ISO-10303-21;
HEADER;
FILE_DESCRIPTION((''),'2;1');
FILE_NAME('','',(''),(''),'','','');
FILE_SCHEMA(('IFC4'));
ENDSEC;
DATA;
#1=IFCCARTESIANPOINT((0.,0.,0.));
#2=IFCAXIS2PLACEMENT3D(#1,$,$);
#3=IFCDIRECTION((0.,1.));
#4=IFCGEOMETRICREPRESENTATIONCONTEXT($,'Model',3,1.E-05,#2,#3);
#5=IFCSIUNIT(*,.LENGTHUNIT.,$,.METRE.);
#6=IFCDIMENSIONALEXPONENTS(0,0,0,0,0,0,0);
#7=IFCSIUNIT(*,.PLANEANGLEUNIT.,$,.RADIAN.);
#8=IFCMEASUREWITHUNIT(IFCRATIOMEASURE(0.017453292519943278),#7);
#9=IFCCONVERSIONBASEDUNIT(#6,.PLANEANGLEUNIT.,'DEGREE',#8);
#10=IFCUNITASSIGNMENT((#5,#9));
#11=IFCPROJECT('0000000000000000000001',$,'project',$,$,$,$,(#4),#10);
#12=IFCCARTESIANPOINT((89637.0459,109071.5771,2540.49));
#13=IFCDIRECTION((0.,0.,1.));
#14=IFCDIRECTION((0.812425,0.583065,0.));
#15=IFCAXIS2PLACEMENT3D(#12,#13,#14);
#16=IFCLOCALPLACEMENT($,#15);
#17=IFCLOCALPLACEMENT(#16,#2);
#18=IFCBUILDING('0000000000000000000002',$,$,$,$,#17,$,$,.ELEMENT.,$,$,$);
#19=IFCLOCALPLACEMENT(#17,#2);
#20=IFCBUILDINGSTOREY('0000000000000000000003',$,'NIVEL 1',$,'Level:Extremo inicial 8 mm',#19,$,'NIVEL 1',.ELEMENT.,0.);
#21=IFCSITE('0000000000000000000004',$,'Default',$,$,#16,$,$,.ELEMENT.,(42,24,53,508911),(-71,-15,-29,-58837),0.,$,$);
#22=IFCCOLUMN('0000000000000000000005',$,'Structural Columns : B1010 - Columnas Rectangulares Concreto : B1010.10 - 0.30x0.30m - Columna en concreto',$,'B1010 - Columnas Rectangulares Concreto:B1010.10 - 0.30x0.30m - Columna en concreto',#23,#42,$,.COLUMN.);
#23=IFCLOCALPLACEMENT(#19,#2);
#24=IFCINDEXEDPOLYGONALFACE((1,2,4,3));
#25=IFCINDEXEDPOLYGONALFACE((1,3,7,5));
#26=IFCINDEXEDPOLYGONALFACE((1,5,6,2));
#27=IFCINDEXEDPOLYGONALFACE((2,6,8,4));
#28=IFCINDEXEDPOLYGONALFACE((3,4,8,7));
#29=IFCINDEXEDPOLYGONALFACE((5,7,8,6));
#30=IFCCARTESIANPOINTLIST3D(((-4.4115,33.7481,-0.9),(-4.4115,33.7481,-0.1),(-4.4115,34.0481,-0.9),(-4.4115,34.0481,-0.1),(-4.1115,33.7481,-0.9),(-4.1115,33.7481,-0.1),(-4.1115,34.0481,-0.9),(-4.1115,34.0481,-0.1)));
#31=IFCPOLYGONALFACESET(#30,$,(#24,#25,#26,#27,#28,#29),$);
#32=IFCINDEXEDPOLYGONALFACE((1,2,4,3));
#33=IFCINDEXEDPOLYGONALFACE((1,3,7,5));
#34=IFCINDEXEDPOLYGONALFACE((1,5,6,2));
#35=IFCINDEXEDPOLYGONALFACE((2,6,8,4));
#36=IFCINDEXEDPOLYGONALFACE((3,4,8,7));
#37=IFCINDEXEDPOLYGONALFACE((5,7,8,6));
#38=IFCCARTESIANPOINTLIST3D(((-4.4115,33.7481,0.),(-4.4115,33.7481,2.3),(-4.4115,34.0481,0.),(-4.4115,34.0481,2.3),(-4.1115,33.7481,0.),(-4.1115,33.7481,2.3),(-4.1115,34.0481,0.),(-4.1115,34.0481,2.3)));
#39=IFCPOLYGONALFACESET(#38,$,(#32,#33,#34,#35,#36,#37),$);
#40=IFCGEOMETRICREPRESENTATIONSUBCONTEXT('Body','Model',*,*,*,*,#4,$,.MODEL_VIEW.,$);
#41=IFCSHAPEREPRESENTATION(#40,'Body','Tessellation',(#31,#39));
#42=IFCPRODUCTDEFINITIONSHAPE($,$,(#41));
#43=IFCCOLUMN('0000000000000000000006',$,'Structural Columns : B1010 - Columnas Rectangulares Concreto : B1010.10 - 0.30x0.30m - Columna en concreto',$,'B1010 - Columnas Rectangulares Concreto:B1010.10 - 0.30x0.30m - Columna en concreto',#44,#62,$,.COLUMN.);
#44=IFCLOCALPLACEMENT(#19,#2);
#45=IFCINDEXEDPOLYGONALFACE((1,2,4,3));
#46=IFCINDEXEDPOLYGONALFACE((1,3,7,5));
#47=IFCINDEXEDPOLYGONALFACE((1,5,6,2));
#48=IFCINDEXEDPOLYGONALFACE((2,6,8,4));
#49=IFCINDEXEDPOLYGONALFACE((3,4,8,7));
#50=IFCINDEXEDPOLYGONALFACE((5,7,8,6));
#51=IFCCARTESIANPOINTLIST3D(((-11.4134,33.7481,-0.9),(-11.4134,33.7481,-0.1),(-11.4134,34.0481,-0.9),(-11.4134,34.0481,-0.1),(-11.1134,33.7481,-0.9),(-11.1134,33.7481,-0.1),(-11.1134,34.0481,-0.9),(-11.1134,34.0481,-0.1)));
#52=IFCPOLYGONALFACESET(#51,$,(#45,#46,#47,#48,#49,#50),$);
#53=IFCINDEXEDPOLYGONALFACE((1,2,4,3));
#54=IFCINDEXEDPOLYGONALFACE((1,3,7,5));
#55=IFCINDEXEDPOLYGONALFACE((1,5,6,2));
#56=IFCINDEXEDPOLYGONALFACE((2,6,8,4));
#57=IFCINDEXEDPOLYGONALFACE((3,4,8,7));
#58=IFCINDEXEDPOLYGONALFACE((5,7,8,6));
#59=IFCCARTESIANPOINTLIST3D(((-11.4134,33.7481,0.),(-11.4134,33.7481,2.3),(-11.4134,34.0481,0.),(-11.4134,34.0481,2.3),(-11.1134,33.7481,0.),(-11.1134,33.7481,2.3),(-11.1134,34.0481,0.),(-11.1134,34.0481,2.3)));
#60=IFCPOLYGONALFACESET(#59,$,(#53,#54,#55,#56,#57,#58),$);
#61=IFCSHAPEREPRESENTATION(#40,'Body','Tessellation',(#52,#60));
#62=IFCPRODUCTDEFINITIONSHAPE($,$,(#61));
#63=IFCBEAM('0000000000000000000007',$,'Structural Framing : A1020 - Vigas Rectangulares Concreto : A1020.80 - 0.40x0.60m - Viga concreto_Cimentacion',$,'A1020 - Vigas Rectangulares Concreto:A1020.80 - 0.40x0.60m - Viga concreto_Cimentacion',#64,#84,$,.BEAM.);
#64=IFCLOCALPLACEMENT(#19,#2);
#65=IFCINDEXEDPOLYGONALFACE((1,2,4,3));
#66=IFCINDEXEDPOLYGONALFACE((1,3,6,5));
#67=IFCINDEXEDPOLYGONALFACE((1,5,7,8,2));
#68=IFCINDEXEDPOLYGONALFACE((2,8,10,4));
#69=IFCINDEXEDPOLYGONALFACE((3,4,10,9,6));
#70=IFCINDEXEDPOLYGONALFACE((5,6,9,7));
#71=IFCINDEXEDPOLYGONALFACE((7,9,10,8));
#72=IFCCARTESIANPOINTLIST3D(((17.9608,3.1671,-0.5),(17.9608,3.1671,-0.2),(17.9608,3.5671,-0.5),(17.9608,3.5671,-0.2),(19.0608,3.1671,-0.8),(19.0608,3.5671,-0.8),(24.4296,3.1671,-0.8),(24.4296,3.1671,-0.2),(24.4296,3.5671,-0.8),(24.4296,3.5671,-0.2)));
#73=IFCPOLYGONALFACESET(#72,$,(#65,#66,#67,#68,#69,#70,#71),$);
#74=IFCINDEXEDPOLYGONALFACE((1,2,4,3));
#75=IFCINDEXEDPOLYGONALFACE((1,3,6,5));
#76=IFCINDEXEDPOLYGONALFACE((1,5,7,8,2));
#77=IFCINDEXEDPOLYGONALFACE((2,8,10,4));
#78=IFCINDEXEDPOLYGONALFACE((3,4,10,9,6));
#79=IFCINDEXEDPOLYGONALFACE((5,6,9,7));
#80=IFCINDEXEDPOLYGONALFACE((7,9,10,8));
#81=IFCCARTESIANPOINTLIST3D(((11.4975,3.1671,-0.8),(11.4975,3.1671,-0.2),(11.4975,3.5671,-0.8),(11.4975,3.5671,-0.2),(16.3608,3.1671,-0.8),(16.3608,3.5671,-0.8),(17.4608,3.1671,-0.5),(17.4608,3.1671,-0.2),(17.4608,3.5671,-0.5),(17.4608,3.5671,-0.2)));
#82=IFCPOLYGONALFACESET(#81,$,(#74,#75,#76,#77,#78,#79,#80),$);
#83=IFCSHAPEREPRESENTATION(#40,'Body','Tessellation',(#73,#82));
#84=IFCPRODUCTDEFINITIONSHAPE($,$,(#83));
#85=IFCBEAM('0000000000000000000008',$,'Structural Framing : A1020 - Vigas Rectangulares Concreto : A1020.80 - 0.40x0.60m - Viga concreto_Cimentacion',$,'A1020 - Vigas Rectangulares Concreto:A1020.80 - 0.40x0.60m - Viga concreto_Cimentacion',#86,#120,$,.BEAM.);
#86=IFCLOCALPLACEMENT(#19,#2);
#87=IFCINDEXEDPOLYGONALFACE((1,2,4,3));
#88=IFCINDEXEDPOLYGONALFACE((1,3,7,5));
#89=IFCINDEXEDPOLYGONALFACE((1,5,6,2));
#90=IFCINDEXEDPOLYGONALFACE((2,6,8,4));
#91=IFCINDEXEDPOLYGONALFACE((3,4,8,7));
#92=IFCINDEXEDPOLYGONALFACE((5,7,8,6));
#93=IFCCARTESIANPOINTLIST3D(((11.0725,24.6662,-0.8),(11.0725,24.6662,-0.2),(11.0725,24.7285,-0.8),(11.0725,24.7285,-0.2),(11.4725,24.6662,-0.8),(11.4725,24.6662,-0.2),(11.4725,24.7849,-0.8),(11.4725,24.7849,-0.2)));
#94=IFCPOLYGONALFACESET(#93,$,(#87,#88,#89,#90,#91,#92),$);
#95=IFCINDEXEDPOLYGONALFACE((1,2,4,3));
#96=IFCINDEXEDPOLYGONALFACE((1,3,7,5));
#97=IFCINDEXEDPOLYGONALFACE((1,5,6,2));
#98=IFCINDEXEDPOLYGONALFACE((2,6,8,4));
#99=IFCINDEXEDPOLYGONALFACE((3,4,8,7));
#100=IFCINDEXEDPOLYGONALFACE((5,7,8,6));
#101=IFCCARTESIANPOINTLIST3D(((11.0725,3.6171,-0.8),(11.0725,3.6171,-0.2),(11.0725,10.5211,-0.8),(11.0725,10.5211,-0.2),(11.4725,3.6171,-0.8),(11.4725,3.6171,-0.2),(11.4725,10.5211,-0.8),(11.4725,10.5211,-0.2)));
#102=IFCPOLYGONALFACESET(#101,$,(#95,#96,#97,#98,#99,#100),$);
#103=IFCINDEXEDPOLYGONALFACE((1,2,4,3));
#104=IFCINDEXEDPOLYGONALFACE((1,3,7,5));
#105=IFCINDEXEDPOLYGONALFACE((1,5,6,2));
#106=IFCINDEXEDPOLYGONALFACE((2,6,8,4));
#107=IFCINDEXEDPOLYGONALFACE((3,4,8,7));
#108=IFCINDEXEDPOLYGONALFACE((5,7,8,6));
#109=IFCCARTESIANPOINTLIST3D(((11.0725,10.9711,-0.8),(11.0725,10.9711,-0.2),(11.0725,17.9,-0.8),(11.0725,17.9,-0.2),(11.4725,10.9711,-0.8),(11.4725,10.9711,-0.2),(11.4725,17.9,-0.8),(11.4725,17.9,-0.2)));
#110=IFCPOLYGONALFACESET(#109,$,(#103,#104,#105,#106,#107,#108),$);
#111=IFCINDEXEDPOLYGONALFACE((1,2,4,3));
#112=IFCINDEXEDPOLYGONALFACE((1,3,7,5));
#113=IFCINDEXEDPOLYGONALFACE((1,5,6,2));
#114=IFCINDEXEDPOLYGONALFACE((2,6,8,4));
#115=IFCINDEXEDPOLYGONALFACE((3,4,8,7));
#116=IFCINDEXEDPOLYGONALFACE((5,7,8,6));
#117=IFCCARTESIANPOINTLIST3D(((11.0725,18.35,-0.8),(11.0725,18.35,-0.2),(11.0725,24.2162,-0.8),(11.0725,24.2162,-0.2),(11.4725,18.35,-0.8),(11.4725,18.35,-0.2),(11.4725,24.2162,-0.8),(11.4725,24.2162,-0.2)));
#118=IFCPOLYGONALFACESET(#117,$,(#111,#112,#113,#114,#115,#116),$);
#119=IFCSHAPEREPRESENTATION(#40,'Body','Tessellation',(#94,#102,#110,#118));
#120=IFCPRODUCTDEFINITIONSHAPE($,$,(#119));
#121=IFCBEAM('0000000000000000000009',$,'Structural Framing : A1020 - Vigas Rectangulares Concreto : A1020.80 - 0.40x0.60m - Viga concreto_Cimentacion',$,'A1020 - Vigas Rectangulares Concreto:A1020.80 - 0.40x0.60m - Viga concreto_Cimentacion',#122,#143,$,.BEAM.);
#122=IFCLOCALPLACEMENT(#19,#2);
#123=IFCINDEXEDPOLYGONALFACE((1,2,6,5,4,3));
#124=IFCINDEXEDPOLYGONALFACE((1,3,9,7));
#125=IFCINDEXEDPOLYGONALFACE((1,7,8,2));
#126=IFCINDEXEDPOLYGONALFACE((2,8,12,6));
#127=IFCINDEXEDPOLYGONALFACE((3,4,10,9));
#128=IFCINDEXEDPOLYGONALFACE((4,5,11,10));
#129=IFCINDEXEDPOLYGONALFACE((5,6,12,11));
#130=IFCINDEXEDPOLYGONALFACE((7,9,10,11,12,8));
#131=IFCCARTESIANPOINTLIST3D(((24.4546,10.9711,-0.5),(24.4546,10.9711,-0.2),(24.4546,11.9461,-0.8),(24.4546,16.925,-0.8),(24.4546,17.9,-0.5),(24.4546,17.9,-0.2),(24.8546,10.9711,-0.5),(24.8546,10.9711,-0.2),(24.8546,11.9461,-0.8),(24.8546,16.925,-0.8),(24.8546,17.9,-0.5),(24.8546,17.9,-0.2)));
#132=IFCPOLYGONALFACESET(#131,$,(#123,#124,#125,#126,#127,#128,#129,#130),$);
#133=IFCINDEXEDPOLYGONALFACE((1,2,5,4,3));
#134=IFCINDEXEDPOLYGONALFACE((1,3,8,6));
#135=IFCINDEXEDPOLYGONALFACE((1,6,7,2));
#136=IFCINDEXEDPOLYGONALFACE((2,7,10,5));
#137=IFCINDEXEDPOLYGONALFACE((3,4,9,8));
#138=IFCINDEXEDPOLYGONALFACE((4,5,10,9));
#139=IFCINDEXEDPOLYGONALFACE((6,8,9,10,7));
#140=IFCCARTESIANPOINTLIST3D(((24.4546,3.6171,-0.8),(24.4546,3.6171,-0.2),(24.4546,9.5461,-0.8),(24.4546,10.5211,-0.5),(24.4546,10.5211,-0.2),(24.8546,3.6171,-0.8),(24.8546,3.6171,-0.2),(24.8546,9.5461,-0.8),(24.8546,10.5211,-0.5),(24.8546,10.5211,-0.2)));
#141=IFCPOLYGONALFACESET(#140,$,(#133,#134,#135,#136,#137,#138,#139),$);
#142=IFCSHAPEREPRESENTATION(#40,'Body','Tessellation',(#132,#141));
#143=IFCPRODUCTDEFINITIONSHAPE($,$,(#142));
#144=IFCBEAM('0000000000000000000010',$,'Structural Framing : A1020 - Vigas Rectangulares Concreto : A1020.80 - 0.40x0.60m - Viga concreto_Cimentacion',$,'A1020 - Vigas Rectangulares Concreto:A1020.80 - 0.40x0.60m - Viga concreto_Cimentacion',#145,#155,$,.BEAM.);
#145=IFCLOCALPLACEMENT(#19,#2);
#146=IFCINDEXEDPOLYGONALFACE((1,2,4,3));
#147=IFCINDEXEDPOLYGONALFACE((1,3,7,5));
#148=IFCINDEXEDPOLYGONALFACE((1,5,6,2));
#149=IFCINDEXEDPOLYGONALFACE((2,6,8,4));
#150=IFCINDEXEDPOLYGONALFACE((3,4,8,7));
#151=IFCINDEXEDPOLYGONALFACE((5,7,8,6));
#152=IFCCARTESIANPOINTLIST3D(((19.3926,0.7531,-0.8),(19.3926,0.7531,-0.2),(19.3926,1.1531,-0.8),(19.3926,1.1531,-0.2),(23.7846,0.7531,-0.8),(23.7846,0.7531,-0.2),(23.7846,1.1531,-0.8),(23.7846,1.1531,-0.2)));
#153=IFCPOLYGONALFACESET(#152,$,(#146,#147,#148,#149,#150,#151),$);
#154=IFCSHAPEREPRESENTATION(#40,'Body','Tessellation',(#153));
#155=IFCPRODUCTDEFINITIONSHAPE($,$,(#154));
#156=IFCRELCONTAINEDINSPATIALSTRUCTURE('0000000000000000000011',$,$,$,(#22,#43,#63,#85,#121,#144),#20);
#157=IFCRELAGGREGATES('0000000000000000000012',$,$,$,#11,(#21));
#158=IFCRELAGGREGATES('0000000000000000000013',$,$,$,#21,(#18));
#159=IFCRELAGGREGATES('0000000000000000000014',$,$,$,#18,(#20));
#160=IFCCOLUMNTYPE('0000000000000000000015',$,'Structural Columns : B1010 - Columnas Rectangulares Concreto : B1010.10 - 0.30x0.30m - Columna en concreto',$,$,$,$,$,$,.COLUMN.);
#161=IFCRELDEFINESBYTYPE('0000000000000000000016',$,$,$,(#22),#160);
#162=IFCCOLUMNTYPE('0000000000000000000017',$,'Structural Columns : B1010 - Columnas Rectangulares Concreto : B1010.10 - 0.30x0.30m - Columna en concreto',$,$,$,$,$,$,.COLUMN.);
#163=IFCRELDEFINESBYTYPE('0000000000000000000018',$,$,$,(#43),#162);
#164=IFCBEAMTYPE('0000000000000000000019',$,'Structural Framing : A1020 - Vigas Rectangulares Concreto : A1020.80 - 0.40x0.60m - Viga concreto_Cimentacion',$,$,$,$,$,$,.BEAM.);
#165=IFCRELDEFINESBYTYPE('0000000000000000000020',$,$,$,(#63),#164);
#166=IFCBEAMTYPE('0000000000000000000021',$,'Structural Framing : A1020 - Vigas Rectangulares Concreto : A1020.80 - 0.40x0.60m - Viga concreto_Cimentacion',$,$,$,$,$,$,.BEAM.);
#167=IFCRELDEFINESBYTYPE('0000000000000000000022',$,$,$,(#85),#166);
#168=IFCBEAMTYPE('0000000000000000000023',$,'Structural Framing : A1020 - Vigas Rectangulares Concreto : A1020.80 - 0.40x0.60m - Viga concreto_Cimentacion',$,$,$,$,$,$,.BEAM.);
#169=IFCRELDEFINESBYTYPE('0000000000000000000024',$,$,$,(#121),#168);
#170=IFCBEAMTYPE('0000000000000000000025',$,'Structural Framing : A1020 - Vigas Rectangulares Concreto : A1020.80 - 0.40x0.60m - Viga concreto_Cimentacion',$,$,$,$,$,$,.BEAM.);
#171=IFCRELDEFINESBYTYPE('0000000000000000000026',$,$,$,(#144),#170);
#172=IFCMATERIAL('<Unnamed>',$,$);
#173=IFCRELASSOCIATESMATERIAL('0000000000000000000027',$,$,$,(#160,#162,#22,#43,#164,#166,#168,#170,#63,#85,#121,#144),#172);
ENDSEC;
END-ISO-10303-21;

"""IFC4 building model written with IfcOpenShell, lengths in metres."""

from ifc_helpers import new_model, entity, si_unit, converted_unit, direction, frame, frame_2d, origin, origin_2d_with_axis, place, context, subcontext, project, spatial, polyline, segment, composite_curve, rectangle, outline, extrude, clip, halfspace, source, transform, mapped, material, material_profile, profile_set, profile_usage, type_object, type_shapes, element, save


model = new_model("IFC4")

# Units and contexts
model_context = context("Model", 3, precision=1e-05, world=origin(), true_north=direction((0.0, 1.0)))
body_context = subcontext(model_context, "Body", "Model", "MODEL_VIEW")
ifc_project = project(units=[si_unit("LENGTHUNIT", "METRE"), converted_unit("PLANEANGLEUNIT", "DEGREE", entity("IfcRatioMeasure", 0.017453292519943278), si_unit("PLANEANGLEUNIT", "RADIAN"), dimensions=[0, 0, 0, 0, 0, 0, 0])], contexts=[model_context])

# Site, building, storey
site_placement = place(None, frame((89637.0459, 109071.5771, 2540.49), z_axis=(0.0, 0.0, 1.0), x_axis=(0.812425, 0.583065, 0.0)))
site = spatial("IfcSite", under=ifc_project, at=site_placement, Name="Default", CompositionType="ELEMENT", RefLatitude=(42, 24, 53, 508911), RefLongitude=(-71, -15, -29, -58837), RefElevation=0.0)
building_placement = place(site_placement, origin())
building = spatial("IfcBuilding", under=site, at=building_placement, CompositionType="ELEMENT")
storey_placement = place(building_placement, origin())
storey = spatial("IfcBuildingStorey", under=building, at=storey_placement, Name="NIVEL 1", ObjectType="Level:Extremo inicial 8 mm", LongName="NIVEL 1", CompositionType="ELEMENT", Elevation=0.0)

# Columns
ifc_material_1 = material(Name="<Unnamed>")
ifc_material_profile_1 = material_profile(ifc_material_1, outline(composite_curve([segment(polyline([(0.15, 0.15, 0.0), (0.15, -0.15, 0.0)]), True, "CONTINUOUS"), segment(polyline([(0.15, -0.15, 0.0), (-0.15, -0.15, 0.0)]), True, "CONTINUOUS"), segment(polyline([(-0.15, -0.15, 0.0), (-0.15, 0.15, 0.0)]), True, "CONTINUOUS"), segment(polyline([(-0.15, 0.15, 0.0), (0.15, 0.15, 0.0)]), True, "CONTINUOUS")], self_intersect=False), kind="CURVE"), Name="B1010.10 - 0.30x0.30m - Columna en concreto")
ifc_material_profile_2 = material_profile(ifc_material_1, outline(composite_curve([segment(polyline([(0.15, 0.15, 2.3), (-0.15, 0.15, 2.3)]), True, "CONTINUOUS"), segment(polyline([(-0.15, 0.15, 2.3), (-0.15, -0.15, 2.3)]), True, "CONTINUOUS"), segment(polyline([(-0.15, -0.15, 2.3), (0.15, -0.15, 2.3)]), True, "CONTINUOUS"), segment(polyline([(0.15, -0.15, 2.3), (0.15, 0.15, 2.3)]), True, "CONTINUOUS")], self_intersect=False), kind="CURVE"), Name="B1010.10 - 0.30x0.30m - Columna en concreto")
ifc_profile_set_1 = profile_set([ifc_material_profile_1, ifc_material_profile_2], Name="B1010.10 - 0.30x0.30m - Columna en concreto")
ifc_profile_usage_1 = profile_usage(ifc_profile_set_1)
column_type_1 = type_object("IfcColumnType", Name="Structural Columns : B1010 - Columnas Rectangulares Concreto : B1010.10 - 0.30x0.30m - Columna en concreto", PredefinedType="COLUMN", material=ifc_profile_set_1)
shared_shape_1 = source(origin(), body_context, "Body", "SweptSolid", [
    extrude(rectangle(XDim=0.3, YDim=0.3, at=origin_2d_with_axis()), frame((-4.2615, 33.8981, -0.9), z_axis=(0.0, 0.0, 1.0), x_axis=(0.0, -1.0, 0.0)), (0.0, 0.0, 1.0), 0.8),
    extrude(rectangle(XDim=0.3, YDim=0.3, at=origin_2d_with_axis()), frame((-4.2615, 33.8981, 0.0), z_axis=(0.0, 0.0, 1.0), x_axis=(0.0, -1.0, 0.0)), (0.0, 0.0, 1.0), 2.3),
])
type_shapes(column_type_1, [shared_shape_1])
column_1_placement = place(storey_placement, origin())
element("IfcColumn", 1, at=column_1_placement, inside=storey, type_object=column_type_1, material=ifc_profile_usage_1, Name="Structural Columns : B1010 - Columnas Rectangulares Concreto : B1010.10 - 0.30x0.30m - Columna en concreto", ObjectType="B1010 - Columnas Rectangulares Concreto:B1010.10 - 0.30x0.30m - Columna en concreto", PredefinedType="COLUMN", context=body_context, shape_type="MappedRepresentation", body=[
    mapped(shared_shape_1, transform((0.0, 0.0, 0.0), scale=1.0)),
])
ifc_profile_usage_2 = profile_usage(ifc_profile_set_1)
column_type_2 = type_object("IfcColumnType", Name="Structural Columns : B1010 - Columnas Rectangulares Concreto : B1010.10 - 0.30x0.30m - Columna en concreto", PredefinedType="COLUMN", material=ifc_profile_set_1)
shared_shape_2 = source(origin(), body_context, "Body", "SweptSolid", [
    extrude(rectangle(XDim=0.3, YDim=0.3, at=origin_2d_with_axis()), frame((-11.2634, 33.8981, -0.9), z_axis=(0.0, 0.0, 1.0), x_axis=(0.0, -1.0, 0.0)), (0.0, 0.0, 1.0), 0.8),
    extrude(rectangle(XDim=0.3, YDim=0.3, at=origin_2d_with_axis()), frame((-11.2634, 33.8981, 0.0), z_axis=(0.0, 0.0, 1.0), x_axis=(0.0, -1.0, 0.0)), (0.0, 0.0, 1.0), 2.3),
])
type_shapes(column_type_2, [shared_shape_2])
column_2_placement = place(storey_placement, origin())
element("IfcColumn", 2, at=column_2_placement, inside=storey, type_object=column_type_2, material=ifc_profile_usage_2, Name="Structural Columns : B1010 - Columnas Rectangulares Concreto : B1010.10 - 0.30x0.30m - Columna en concreto", ObjectType="B1010 - Columnas Rectangulares Concreto:B1010.10 - 0.30x0.30m - Columna en concreto", PredefinedType="COLUMN", context=body_context, shape_type="MappedRepresentation", body=[
    mapped(shared_shape_2, transform((0.0, 0.0, 0.0), scale=1.0)),
])

# Beams
ifc_material_profile_3 = material_profile(ifc_material_1, outline(composite_curve([segment(polyline([(-0.2, 0.3, 0.0), (0.2, 0.3, 0.0)]), True, "CONTINUOUS"), segment(polyline([(0.2, 0.3, 0.0), (0.2, -0.3, 0.0)]), True, "CONTINUOUS"), segment(polyline([(0.2, -0.3, 0.0), (-0.2, -0.3, 0.0)]), True, "CONTINUOUS"), segment(polyline([(-0.2, -0.3, 0.0), (-0.2, 0.3, 0.0)]), True, "CONTINUOUS")], self_intersect=False), kind="CURVE"), Name="A1020.80 - 0.40x0.60m - Viga concreto_Cimentacion")
ifc_material_profile_4 = material_profile(ifc_material_1, outline(composite_curve([segment(polyline([(6.4409, -0.2, 0.3), (6.4409, -0.2, -0.3)]), True, "CONTINUOUS"), segment(polyline([(6.4409, -0.2, -0.3), (6.4409, 0.2, -0.3)]), True, "CONTINUOUS"), segment(polyline([(6.4409, 0.2, -0.3), (6.4409, 0.2, 0.3)]), True, "CONTINUOUS"), segment(polyline([(6.4409, 0.2, 0.3), (6.4409, -0.2, 0.3)]), True, "CONTINUOUS")], self_intersect=False), kind="CURVE"), Name="A1020.80 - 0.40x0.60m - Viga concreto_Cimentacion")
ifc_profile_set_2 = profile_set([ifc_material_profile_3, ifc_material_profile_4], Name="A1020.80 - 0.40x0.60m - Viga concreto_Cimentacion")
ifc_profile_usage_3 = profile_usage(ifc_profile_set_2, cardinal=8)
beam_type_1 = type_object("IfcBeamType", Name="Structural Framing : A1020 - Vigas Rectangulares Concreto : A1020.80 - 0.40x0.60m - Viga concreto_Cimentacion", PredefinedType="BEAM", material=ifc_profile_set_2)
shared_shape_3 = source(origin(), body_context, "Body", "SweptSolid", [
    clip(extrude(rectangle(XDim=0.6, YDim=0.4, at=frame_2d((0.0, 0.0), x_axis=(0.0, 1.0))), frame((17.9608, 3.3671, -0.5), z_axis=(1.0, 0.0, 0.0), x_axis=(0.0, 1.0, 0.0)), (0.0, 0.0, 1.0), 6.4688), halfspace(frame((19.0608, 3.3671, -0.8), z_axis=(-0.263117, 0.0, -0.964764), x_axis=(0.0, 1.0, 0.0)), False)),
    clip(extrude(rectangle(XDim=0.6, YDim=0.4, at=frame_2d((0.0, 0.0), x_axis=(0.0, 1.0))), frame((11.4975, 3.3671, -0.5), z_axis=(1.0, 0.0, 0.0), x_axis=(0.0, 1.0, 0.0)), (0.0, 0.0, 1.0), 5.9633), halfspace(frame((16.3608, 3.3671, -0.8), z_axis=(0.263117, 0.0, -0.964764), x_axis=(0.0, -1.0, 0.0)), False)),
])
type_shapes(beam_type_1, [shared_shape_3])
beam_1_placement = place(storey_placement, origin())
element("IfcBeam", 3, at=beam_1_placement, inside=storey, type_object=beam_type_1, material=ifc_profile_usage_3, Name="Structural Framing : A1020 - Vigas Rectangulares Concreto : A1020.80 - 0.40x0.60m - Viga concreto_Cimentacion", ObjectType="A1020 - Vigas Rectangulares Concreto:A1020.80 - 0.40x0.60m - Viga concreto_Cimentacion", PredefinedType="BEAM", context=body_context, shape_type="MappedRepresentation", body=[
    mapped(shared_shape_3, transform((0.0, 0.0, 0.0), scale=1.0)),
])
ifc_profile_usage_4 = profile_usage(ifc_profile_set_2, cardinal=8)
beam_type_2 = type_object("IfcBeamType", Name="Structural Framing : A1020 - Vigas Rectangulares Concreto : A1020.80 - 0.40x0.60m - Viga concreto_Cimentacion", PredefinedType="BEAM", material=ifc_profile_set_2)
shared_shape_4 = source(origin(), body_context, "Body", "SweptSolid", [
    clip(extrude(rectangle(XDim=0.6, YDim=0.4, at=frame_2d((0.0, 0.0), x_axis=(0.0, 1.0))), frame((11.2725, 24.6662, -0.5), z_axis=(0.0, 1.0, 0.0), x_axis=(-1.0, 0.0, 0.0)), (0.0, 0.0, 1.0), 0.1187), halfspace(frame((10.9962, 24.7178, -0.2), z_axis=(-0.139655, 0.9902, 0.0), x_axis=(0.9902, 0.139655, 0.0)), False)),
    extrude(rectangle(XDim=0.6, YDim=0.4, at=frame_2d((0.0, 0.0), x_axis=(0.0, 1.0))), frame((11.2725, 3.6171, -0.5), z_axis=(0.0, 1.0, 0.0), x_axis=(-1.0, 0.0, 0.0)), (0.0, 0.0, 1.0), 6.904),
    extrude(rectangle(XDim=0.6, YDim=0.4, at=frame_2d((0.0, 0.0), x_axis=(0.0, 1.0))), frame((11.2725, 10.9711, -0.5), z_axis=(0.0, 1.0, 0.0), x_axis=(-1.0, 0.0, 0.0)), (0.0, 0.0, 1.0), 6.929),
    extrude(rectangle(XDim=0.6, YDim=0.4, at=frame_2d((0.0, 0.0), x_axis=(0.0, 1.0))), frame((11.2725, 18.35, -0.5), z_axis=(0.0, 1.0, 0.0), x_axis=(-1.0, 0.0, 0.0)), (0.0, 0.0, 1.0), 5.8662),
])
type_shapes(beam_type_2, [shared_shape_4])
beam_2_placement = place(storey_placement, origin())
element("IfcBeam", 4, at=beam_2_placement, inside=storey, type_object=beam_type_2, material=ifc_profile_usage_4, Name="Structural Framing : A1020 - Vigas Rectangulares Concreto : A1020.80 - 0.40x0.60m - Viga concreto_Cimentacion", ObjectType="A1020 - Vigas Rectangulares Concreto:A1020.80 - 0.40x0.60m - Viga concreto_Cimentacion", PredefinedType="BEAM", context=body_context, shape_type="MappedRepresentation", body=[
    mapped(shared_shape_4, transform((0.0, 0.0, 0.0), scale=1.0)),
])
ifc_profile_usage_5 = profile_usage(ifc_profile_set_2, cardinal=8)
beam_type_3 = type_object("IfcBeamType", Name="Structural Framing : A1020 - Vigas Rectangulares Concreto : A1020.80 - 0.40x0.60m - Viga concreto_Cimentacion", PredefinedType="BEAM", material=ifc_profile_set_2)
shared_shape_5 = source(origin(), body_context, "Body", "SweptSolid", [
    clip(clip(extrude(rectangle(XDim=0.6, YDim=0.4, at=frame_2d((0.0, 0.0), x_axis=(0.0, 1.0))), frame((24.6546, 10.9711, -0.5), z_axis=(0.0, 1.0, 0.0), x_axis=(-1.0, 0.0, 0.0)), (0.0, 0.0, 1.0), 6.929), halfspace(frame((24.6546, 11.9461, -0.8), z_axis=(0.0, -0.294086, -0.955779), x_axis=(-1.0, 0.0, 0.0)), False)), halfspace(frame((24.6546, 16.925, -0.8), z_axis=(0.0, 0.294086, -0.955779), x_axis=(1.0, 0.0, 0.0)), False)),
    clip(extrude(rectangle(XDim=0.6, YDim=0.4, at=frame_2d((0.0, 0.0), x_axis=(0.0, 1.0))), frame((24.6546, 3.6171, -0.5), z_axis=(0.0, 1.0, 0.0), x_axis=(-1.0, 0.0, 0.0)), (0.0, 0.0, 1.0), 6.904), halfspace(frame((24.6546, 9.5461, -0.8), z_axis=(0.0, 0.294086, -0.955779), x_axis=(1.0, 0.0, 0.0)), False)),
])
type_shapes(beam_type_3, [shared_shape_5])
beam_3_placement = place(storey_placement, origin())
element("IfcBeam", 5, at=beam_3_placement, inside=storey, type_object=beam_type_3, material=ifc_profile_usage_5, Name="Structural Framing : A1020 - Vigas Rectangulares Concreto : A1020.80 - 0.40x0.60m - Viga concreto_Cimentacion", ObjectType="A1020 - Vigas Rectangulares Concreto:A1020.80 - 0.40x0.60m - Viga concreto_Cimentacion", PredefinedType="BEAM", context=body_context, shape_type="MappedRepresentation", body=[
    mapped(shared_shape_5, transform((0.0, 0.0, 0.0), scale=1.0)),
])
ifc_profile_usage_6 = profile_usage(ifc_profile_set_2, cardinal=8)
beam_type_4 = type_object("IfcBeamType", Name="Structural Framing : A1020 - Vigas Rectangulares Concreto : A1020.80 - 0.40x0.60m - Viga concreto_Cimentacion", PredefinedType="BEAM", material=ifc_profile_set_2)
shared_shape_6 = source(origin(), body_context, "Body", "SweptSolid", [
    extrude(rectangle(XDim=0.6, YDim=0.4, at=frame_2d((0.0, 0.0), x_axis=(1.0, 0.0))), frame((19.3926, 0.9531, -0.5), z_axis=(1.0, 0.0, 0.0), x_axis=(0.0, 0.0, -1.0)), (0.0, 0.0, 1.0), 4.3921),
])
type_shapes(beam_type_4, [shared_shape_6])
beam_4_placement = place(storey_placement, origin())
element("IfcBeam", 6, at=beam_4_placement, inside=storey, type_object=beam_type_4, material=ifc_profile_usage_6, Name="Structural Framing : A1020 - Vigas Rectangulares Concreto : A1020.80 - 0.40x0.60m - Viga concreto_Cimentacion", ObjectType="A1020 - Vigas Rectangulares Concreto:A1020.80 - 0.40x0.60m - Viga concreto_Cimentacion", PredefinedType="BEAM", context=body_context, shape_type="MappedRepresentation", body=[
    mapped(shared_shape_6, transform((0.0, 0.0, 0.0), scale=1.0)),
])

save(model, "model.ifc")
